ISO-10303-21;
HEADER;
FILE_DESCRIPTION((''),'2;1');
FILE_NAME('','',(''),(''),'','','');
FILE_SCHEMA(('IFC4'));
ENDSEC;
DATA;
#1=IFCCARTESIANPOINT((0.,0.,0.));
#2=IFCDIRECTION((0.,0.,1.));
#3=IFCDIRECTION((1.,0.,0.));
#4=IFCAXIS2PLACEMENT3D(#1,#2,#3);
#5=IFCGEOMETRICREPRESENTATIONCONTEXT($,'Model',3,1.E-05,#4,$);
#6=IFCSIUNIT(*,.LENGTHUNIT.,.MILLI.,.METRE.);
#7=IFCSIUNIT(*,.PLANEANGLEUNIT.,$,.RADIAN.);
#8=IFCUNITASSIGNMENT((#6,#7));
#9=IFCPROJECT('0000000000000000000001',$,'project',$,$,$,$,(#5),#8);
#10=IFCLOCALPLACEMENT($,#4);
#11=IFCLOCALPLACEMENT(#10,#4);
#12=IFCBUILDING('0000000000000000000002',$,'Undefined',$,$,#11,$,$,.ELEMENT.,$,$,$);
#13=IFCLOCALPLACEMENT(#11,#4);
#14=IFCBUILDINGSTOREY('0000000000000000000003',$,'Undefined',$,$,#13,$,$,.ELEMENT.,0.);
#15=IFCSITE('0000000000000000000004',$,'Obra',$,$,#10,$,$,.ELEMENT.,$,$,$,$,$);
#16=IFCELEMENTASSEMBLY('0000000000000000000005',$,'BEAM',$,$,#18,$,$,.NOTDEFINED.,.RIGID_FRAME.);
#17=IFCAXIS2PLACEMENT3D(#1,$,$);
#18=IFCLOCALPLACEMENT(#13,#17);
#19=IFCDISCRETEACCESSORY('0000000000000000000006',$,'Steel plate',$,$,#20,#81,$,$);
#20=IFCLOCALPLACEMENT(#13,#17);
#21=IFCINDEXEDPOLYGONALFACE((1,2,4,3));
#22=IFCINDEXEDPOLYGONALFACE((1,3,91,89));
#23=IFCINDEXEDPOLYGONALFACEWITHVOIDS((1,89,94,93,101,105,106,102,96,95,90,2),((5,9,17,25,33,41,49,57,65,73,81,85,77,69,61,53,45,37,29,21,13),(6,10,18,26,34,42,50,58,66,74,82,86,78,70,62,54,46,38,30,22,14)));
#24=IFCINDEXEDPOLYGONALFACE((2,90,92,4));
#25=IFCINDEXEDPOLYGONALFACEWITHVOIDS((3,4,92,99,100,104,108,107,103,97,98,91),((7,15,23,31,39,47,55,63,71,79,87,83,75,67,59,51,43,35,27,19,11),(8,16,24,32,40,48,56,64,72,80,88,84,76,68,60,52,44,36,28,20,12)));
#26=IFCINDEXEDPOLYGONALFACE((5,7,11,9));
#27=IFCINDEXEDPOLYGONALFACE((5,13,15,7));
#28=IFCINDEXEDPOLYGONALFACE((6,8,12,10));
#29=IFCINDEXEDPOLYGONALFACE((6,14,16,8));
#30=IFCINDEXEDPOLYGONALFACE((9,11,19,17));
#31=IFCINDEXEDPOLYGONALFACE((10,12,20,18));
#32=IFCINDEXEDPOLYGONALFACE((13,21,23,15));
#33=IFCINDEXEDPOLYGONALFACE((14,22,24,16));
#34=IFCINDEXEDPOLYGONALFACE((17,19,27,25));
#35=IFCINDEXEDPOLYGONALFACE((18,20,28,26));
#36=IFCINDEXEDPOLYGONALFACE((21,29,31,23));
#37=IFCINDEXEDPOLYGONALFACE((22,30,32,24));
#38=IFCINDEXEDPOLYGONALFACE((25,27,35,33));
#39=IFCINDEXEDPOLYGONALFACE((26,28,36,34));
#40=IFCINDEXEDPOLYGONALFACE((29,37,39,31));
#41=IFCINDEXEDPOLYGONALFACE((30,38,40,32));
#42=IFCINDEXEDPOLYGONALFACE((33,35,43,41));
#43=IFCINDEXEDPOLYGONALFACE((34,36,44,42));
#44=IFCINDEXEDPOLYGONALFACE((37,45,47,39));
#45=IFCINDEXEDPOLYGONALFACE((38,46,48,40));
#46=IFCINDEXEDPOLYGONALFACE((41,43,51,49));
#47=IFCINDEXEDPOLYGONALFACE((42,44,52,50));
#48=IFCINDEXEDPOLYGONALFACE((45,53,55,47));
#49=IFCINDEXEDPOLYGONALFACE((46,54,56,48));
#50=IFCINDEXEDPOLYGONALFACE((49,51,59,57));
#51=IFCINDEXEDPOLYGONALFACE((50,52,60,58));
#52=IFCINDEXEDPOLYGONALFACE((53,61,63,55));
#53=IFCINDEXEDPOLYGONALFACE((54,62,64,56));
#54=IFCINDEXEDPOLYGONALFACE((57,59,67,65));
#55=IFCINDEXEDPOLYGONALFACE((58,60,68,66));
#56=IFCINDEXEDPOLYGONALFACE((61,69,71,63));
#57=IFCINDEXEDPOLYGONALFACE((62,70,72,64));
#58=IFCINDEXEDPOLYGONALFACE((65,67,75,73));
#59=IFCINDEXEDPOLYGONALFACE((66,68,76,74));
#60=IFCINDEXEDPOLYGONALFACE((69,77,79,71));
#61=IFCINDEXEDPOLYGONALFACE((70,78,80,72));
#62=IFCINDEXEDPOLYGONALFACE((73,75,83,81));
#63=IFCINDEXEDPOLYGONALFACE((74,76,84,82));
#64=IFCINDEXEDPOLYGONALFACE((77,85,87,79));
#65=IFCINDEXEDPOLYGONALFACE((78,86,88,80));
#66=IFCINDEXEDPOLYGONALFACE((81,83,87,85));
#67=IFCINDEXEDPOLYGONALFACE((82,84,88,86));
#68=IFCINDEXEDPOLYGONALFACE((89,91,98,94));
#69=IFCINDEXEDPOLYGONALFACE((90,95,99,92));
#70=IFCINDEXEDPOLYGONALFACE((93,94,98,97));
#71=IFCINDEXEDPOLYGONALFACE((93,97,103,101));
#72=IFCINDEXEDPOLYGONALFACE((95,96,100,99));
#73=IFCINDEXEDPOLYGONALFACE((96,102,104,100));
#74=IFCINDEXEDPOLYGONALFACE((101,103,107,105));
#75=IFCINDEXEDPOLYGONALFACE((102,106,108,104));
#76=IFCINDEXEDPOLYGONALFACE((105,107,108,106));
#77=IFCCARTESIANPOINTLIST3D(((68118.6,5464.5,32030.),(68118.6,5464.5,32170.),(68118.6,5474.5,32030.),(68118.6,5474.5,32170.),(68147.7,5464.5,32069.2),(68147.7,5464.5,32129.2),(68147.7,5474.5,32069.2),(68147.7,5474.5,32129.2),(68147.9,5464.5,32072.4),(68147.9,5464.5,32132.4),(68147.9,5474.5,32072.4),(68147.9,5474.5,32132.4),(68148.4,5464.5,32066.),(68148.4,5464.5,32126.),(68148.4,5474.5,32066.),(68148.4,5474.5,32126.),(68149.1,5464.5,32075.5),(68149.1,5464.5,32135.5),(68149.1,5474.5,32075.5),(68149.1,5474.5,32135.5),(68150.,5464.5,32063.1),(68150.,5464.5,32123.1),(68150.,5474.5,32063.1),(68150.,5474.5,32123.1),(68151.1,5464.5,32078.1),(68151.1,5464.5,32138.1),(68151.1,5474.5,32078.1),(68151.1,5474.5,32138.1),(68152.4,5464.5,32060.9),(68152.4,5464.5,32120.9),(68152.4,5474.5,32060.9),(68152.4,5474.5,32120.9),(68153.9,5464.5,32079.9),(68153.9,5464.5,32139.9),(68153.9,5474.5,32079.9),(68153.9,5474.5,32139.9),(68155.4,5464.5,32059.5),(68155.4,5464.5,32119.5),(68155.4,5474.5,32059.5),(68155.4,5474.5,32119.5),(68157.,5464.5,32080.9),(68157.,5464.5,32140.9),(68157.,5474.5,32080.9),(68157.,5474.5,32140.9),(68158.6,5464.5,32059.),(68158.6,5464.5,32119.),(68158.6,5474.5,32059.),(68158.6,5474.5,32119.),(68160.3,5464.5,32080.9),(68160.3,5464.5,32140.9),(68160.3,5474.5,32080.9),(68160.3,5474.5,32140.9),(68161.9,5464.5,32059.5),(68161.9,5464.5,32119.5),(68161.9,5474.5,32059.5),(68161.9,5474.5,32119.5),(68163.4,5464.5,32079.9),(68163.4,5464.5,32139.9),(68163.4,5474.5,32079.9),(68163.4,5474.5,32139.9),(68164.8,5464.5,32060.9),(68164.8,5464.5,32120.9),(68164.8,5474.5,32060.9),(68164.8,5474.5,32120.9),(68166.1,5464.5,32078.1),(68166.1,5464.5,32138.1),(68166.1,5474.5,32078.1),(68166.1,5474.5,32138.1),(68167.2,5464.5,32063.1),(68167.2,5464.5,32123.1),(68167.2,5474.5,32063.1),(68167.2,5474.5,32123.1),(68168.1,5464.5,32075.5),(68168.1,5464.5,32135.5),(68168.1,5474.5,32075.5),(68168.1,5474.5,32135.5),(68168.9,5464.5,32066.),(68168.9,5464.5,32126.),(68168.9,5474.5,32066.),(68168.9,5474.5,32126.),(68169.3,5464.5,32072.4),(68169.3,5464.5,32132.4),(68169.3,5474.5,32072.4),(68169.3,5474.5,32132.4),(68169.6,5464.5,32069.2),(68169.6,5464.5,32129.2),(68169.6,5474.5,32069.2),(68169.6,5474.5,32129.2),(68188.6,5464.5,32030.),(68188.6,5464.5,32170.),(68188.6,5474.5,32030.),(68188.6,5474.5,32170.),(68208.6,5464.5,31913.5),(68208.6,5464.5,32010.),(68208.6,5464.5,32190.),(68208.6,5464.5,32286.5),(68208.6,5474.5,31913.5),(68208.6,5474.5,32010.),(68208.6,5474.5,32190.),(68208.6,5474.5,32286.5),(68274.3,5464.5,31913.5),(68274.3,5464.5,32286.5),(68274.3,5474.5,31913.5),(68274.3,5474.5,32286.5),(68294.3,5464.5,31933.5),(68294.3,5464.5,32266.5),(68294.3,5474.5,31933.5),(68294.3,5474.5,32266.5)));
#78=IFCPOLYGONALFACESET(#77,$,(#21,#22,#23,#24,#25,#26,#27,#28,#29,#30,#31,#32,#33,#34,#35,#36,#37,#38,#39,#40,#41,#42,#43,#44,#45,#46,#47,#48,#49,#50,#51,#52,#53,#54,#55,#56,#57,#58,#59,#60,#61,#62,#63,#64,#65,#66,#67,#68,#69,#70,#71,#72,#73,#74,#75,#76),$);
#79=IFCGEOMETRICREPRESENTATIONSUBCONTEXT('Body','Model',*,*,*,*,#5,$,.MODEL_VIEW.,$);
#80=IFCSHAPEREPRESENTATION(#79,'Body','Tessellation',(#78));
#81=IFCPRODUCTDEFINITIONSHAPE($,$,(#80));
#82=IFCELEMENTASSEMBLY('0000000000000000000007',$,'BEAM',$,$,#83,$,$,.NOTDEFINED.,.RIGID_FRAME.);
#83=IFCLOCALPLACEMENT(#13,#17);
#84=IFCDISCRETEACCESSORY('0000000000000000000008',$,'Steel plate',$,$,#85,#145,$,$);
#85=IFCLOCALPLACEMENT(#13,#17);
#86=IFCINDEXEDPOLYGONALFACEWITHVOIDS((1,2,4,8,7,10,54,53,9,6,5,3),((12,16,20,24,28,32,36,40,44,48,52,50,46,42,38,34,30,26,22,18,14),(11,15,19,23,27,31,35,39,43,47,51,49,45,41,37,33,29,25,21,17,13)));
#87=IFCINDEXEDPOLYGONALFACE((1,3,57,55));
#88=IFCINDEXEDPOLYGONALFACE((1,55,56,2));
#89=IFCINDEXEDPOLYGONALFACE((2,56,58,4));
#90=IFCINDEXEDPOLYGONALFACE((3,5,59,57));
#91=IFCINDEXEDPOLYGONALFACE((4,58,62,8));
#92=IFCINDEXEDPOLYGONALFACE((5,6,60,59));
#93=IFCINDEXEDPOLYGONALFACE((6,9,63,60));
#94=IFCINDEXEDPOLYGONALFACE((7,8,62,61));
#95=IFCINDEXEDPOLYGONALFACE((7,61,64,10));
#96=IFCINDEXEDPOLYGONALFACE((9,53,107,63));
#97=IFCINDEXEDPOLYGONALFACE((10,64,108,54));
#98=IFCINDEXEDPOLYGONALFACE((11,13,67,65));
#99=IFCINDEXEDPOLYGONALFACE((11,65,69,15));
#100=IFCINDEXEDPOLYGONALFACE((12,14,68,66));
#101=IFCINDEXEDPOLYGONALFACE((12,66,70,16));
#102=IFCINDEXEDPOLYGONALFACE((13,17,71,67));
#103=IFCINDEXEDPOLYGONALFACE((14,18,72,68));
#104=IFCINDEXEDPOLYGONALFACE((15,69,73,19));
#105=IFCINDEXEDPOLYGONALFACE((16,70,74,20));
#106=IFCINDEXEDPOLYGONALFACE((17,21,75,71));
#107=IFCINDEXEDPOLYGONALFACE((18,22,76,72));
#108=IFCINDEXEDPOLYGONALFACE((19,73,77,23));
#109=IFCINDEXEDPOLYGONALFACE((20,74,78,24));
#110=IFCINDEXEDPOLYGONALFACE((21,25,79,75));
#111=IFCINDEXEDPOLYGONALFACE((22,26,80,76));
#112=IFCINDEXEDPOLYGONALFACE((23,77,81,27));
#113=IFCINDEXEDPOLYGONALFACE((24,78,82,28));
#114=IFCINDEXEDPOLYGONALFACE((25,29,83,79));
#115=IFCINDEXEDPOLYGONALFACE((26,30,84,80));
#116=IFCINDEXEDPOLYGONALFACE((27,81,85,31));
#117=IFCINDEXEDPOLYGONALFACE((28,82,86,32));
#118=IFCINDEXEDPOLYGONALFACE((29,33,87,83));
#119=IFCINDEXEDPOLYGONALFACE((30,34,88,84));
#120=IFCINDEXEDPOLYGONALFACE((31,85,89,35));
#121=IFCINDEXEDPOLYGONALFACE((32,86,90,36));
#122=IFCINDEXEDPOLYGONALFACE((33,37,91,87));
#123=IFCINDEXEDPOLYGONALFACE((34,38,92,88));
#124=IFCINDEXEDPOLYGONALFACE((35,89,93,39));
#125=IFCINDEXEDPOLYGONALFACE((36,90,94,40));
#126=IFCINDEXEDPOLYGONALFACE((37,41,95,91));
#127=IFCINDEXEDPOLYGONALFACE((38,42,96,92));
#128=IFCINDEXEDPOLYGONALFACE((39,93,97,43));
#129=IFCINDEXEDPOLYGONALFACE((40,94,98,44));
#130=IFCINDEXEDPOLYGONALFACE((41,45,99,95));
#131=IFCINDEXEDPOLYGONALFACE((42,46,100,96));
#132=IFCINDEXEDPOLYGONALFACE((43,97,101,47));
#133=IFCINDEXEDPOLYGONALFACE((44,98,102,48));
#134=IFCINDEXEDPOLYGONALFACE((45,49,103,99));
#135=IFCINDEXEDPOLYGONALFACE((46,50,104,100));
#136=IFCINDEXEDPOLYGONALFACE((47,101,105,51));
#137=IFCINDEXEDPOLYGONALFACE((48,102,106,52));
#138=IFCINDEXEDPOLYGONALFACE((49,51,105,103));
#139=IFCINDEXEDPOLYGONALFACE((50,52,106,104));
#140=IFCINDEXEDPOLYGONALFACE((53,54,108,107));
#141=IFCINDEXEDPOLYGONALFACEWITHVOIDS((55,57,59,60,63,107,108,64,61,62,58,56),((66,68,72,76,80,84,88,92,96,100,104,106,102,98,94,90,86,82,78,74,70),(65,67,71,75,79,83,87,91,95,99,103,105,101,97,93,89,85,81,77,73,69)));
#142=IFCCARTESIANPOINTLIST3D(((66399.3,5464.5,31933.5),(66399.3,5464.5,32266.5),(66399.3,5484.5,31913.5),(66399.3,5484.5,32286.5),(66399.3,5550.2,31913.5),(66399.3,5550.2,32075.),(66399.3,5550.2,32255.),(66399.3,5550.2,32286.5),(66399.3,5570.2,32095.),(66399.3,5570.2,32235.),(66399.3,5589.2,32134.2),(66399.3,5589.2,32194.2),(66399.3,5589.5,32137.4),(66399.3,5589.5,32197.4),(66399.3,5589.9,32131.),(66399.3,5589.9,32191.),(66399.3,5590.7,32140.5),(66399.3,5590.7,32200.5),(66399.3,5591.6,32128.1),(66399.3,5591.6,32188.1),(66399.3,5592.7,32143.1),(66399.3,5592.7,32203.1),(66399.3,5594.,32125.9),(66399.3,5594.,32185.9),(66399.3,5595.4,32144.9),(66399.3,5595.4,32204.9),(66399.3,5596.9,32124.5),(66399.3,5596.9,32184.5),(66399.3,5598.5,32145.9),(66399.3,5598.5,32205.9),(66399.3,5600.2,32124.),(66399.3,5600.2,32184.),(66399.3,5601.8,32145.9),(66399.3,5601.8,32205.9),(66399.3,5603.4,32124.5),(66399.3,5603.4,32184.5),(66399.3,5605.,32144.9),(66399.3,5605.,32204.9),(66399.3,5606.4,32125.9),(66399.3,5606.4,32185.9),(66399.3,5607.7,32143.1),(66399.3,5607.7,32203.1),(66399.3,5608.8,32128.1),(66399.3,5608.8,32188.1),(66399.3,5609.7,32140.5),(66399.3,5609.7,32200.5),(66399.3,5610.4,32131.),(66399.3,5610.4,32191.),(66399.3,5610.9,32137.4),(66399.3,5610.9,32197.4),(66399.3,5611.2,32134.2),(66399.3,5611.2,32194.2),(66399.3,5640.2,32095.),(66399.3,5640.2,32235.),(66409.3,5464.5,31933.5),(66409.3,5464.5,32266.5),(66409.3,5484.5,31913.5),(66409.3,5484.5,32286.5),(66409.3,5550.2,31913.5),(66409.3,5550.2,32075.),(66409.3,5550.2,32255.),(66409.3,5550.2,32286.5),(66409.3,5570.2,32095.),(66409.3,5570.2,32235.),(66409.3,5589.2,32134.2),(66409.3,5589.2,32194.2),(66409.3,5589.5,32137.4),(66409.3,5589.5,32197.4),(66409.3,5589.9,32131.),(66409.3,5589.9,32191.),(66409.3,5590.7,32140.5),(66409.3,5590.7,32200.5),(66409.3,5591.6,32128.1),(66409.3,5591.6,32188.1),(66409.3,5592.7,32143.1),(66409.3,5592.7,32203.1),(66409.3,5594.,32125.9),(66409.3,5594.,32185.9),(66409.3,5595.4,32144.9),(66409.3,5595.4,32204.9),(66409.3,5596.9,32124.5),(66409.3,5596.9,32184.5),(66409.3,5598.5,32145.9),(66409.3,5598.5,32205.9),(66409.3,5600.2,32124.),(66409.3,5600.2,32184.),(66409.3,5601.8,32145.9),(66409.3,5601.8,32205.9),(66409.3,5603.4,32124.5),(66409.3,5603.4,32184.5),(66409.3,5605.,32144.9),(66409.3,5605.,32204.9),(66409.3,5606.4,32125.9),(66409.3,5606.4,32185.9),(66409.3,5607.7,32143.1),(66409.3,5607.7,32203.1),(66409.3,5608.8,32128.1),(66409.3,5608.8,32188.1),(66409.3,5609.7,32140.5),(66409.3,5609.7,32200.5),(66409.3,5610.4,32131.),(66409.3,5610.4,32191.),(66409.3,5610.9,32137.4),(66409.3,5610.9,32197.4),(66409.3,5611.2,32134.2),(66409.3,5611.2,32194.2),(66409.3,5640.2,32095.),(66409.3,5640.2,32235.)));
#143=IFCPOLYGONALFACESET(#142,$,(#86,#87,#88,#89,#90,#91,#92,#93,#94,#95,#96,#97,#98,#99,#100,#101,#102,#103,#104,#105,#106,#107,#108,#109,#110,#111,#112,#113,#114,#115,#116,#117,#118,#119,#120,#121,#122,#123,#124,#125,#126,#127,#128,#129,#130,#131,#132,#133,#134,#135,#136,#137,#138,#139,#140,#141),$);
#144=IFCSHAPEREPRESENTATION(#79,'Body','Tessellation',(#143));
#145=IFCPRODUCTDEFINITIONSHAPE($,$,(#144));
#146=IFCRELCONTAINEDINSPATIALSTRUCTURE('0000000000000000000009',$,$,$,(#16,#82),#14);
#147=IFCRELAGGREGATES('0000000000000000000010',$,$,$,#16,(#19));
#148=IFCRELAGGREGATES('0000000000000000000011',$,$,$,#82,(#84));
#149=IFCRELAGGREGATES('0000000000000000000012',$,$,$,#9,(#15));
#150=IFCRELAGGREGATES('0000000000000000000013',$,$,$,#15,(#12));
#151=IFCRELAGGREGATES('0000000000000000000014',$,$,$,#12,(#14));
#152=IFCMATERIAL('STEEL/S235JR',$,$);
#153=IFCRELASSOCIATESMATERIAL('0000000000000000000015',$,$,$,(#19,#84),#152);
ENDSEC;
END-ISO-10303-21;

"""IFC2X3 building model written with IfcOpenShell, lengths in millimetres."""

from ifc_helpers import new_model, si_unit, frame, origin_with_axes, origin_2d_with_axis, place, context, subcontext, project, spatial, polyline, circle, outline, extrude, source, transform, mapped, material, element, aggregate, save


model = new_model("IFC2X3")

# Units and contexts
model_context = context("Model", 3, precision=1e-05, world=origin_with_axes())
body_context = subcontext(model_context, "Body", "Model", "MODEL_VIEW")
ifc_project = project(units=[si_unit("LENGTHUNIT", "METRE", prefix="MILLI"), si_unit("PLANEANGLEUNIT", "RADIAN")], contexts=[model_context])

# Site, building, storey
site_placement = place(None, origin_with_axes())
site = spatial("IfcSite", under=ifc_project, at=site_placement, Name="Obra", CompositionType="ELEMENT")
building_placement = place(site_placement, origin_with_axes())
building = spatial("IfcBuilding", under=site, at=building_placement, Name="Undefined", CompositionType="ELEMENT")
storey_placement = place(building_placement, origin_with_axes())
storey = spatial("IfcBuildingStorey", under=building, at=storey_placement, Name="Undefined", CompositionType="ELEMENT", Elevation=0.0)

# Shared definitions
ifc_material_1 = material(Name="STEEL/S235JR")

# Element assembly, discrete accessory, opening
assembly_1_placement = place(storey_placement, origin_with_axes())
assembly_1 = element("IfcElementAssembly", 1, at=assembly_1_placement, inside=storey, Name="BEAM", AssemblyPlace="NOTDEFINED", PredefinedType="RIGID_FRAME")
discrete_accessory_1_placement = place(assembly_1_placement, frame((68294.3, 5469.5, 31933.5), z_axis=(0.0, 1.0, 0.0), x_axis=(-0.707107, 0.0, -0.707107)))
discrete_accessory_1 = element("IfcDiscreteAccessory", 2, at=discrete_accessory_1_placement, material=ifc_material_1, Name="Steel plate", context=body_context, shape_type="SweptSolid", body=[
    extrude(outline(polyline([(0.0, 0.0), (28.3, 0.0), (74.7, 46.5), (6.5, 114.7), (6.5, 143.0), (56.0, 192.5), (-43.0, 291.5), (-92.5, 242.0), (-120.8, 242.0), (-189.0, 310.2), (-235.5, 263.8), (-235.5, 235.5), (0.0, 0.0)])), frame((0.0, 0.0, -5.0), z_axis=(0.0, 0.0, 1.0), x_axis=(1.0, 0.0, 0.0)), (0.0, 0.0, 1.0), 10.0),
])
shared_shape_1 = source(origin_with_axes(), body_context, "Body", "SweptSolid", [
    extrude(circle(Radius=11.0, at=origin_2d_with_axis()), frame((0.0, -14.4, 0.0), z_axis=(0.0, 1.0, 0.0), x_axis=(1.0, 0.0, 0.0)), (0.0, 0.0, 1.0), 10.2),
])
opening_1_placement = place(assembly_1_placement, frame((68198.6, 5460.2, 32170.0), z_axis=(-1.0, 0.0, 0.0), x_axis=(0.0, 0.0, -1.0)))
element("IfcOpeningElement", 3, at=opening_1_placement, cuts=discrete_accessory_1, ObjectType="Opening", context=body_context, shape_type="MappedRepresentation", body=[
    mapped(shared_shape_1, transform((40.0, 0.0, 40.0))),
    mapped(shared_shape_1, transform((100.0, 0.0, 40.0))),
])
aggregate(assembly_1, [discrete_accessory_1])

# Element assembly, discrete accessory, opening
assembly_2_placement = place(storey_placement, origin_with_axes())
assembly_2 = element("IfcElementAssembly", 4, at=assembly_2_placement, inside=storey, Name="BEAM", AssemblyPlace="NOTDEFINED", PredefinedType="RIGID_FRAME")
discrete_accessory_2_placement = place(assembly_2_placement, frame((66404.3, 5464.5, 31933.5), z_axis=(1.0, 0.0, 0.0), x_axis=(0.0, 0.707107, -0.707107)))
discrete_accessory_2 = element("IfcDiscreteAccessory", 5, at=discrete_accessory_2_placement, material=ifc_material_1, Name="Steel plate", context=body_context, shape_type="SweptSolid", body=[
    extrude(outline(polyline([(0.0, 0.0), (28.3, 0.0), (74.7, 46.5), (-39.5, 160.7), (-39.5, 188.9), (10.0, 238.4), (-89.0, 337.4), (-138.5, 287.9), (-166.7, 287.9), (-189.0, 310.2), (-235.5, 263.8), (-235.5, 235.5), (0.0, 0.0)])), frame((0.0, 0.0, -5.0), z_axis=(0.0, 0.0, 1.0), x_axis=(1.0, 0.0, 0.0)), (0.0, 0.0, 1.0), 10.0),
])
shared_shape_2 = source(origin_with_axes(), body_context, "Body", "SweptSolid", [
    extrude(circle(Radius=11.0, at=origin_2d_with_axis()), frame((0.0, -13.4, 0.0), z_axis=(0.0, 1.0, 0.0), x_axis=(1.0, 0.0, 0.0)), (0.0, 0.0, 1.0), 10.2),
])
opening_2_placement = place(assembly_2_placement, frame((66396.0, 5560.2, 32235.0), z_axis=(0.0, 1.0, 0.0), x_axis=(0.0, 0.0, -1.0)))
element("IfcOpeningElement", 6, at=opening_2_placement, cuts=discrete_accessory_2, ObjectType="Opening", context=body_context, shape_type="MappedRepresentation", body=[
    mapped(shared_shape_2, transform((40.0, 0.0, 40.0))),
    mapped(shared_shape_2, transform((100.0, 0.0, 40.0))),
])
aggregate(assembly_2, [discrete_accessory_2])

save(model, "model.ifc")
